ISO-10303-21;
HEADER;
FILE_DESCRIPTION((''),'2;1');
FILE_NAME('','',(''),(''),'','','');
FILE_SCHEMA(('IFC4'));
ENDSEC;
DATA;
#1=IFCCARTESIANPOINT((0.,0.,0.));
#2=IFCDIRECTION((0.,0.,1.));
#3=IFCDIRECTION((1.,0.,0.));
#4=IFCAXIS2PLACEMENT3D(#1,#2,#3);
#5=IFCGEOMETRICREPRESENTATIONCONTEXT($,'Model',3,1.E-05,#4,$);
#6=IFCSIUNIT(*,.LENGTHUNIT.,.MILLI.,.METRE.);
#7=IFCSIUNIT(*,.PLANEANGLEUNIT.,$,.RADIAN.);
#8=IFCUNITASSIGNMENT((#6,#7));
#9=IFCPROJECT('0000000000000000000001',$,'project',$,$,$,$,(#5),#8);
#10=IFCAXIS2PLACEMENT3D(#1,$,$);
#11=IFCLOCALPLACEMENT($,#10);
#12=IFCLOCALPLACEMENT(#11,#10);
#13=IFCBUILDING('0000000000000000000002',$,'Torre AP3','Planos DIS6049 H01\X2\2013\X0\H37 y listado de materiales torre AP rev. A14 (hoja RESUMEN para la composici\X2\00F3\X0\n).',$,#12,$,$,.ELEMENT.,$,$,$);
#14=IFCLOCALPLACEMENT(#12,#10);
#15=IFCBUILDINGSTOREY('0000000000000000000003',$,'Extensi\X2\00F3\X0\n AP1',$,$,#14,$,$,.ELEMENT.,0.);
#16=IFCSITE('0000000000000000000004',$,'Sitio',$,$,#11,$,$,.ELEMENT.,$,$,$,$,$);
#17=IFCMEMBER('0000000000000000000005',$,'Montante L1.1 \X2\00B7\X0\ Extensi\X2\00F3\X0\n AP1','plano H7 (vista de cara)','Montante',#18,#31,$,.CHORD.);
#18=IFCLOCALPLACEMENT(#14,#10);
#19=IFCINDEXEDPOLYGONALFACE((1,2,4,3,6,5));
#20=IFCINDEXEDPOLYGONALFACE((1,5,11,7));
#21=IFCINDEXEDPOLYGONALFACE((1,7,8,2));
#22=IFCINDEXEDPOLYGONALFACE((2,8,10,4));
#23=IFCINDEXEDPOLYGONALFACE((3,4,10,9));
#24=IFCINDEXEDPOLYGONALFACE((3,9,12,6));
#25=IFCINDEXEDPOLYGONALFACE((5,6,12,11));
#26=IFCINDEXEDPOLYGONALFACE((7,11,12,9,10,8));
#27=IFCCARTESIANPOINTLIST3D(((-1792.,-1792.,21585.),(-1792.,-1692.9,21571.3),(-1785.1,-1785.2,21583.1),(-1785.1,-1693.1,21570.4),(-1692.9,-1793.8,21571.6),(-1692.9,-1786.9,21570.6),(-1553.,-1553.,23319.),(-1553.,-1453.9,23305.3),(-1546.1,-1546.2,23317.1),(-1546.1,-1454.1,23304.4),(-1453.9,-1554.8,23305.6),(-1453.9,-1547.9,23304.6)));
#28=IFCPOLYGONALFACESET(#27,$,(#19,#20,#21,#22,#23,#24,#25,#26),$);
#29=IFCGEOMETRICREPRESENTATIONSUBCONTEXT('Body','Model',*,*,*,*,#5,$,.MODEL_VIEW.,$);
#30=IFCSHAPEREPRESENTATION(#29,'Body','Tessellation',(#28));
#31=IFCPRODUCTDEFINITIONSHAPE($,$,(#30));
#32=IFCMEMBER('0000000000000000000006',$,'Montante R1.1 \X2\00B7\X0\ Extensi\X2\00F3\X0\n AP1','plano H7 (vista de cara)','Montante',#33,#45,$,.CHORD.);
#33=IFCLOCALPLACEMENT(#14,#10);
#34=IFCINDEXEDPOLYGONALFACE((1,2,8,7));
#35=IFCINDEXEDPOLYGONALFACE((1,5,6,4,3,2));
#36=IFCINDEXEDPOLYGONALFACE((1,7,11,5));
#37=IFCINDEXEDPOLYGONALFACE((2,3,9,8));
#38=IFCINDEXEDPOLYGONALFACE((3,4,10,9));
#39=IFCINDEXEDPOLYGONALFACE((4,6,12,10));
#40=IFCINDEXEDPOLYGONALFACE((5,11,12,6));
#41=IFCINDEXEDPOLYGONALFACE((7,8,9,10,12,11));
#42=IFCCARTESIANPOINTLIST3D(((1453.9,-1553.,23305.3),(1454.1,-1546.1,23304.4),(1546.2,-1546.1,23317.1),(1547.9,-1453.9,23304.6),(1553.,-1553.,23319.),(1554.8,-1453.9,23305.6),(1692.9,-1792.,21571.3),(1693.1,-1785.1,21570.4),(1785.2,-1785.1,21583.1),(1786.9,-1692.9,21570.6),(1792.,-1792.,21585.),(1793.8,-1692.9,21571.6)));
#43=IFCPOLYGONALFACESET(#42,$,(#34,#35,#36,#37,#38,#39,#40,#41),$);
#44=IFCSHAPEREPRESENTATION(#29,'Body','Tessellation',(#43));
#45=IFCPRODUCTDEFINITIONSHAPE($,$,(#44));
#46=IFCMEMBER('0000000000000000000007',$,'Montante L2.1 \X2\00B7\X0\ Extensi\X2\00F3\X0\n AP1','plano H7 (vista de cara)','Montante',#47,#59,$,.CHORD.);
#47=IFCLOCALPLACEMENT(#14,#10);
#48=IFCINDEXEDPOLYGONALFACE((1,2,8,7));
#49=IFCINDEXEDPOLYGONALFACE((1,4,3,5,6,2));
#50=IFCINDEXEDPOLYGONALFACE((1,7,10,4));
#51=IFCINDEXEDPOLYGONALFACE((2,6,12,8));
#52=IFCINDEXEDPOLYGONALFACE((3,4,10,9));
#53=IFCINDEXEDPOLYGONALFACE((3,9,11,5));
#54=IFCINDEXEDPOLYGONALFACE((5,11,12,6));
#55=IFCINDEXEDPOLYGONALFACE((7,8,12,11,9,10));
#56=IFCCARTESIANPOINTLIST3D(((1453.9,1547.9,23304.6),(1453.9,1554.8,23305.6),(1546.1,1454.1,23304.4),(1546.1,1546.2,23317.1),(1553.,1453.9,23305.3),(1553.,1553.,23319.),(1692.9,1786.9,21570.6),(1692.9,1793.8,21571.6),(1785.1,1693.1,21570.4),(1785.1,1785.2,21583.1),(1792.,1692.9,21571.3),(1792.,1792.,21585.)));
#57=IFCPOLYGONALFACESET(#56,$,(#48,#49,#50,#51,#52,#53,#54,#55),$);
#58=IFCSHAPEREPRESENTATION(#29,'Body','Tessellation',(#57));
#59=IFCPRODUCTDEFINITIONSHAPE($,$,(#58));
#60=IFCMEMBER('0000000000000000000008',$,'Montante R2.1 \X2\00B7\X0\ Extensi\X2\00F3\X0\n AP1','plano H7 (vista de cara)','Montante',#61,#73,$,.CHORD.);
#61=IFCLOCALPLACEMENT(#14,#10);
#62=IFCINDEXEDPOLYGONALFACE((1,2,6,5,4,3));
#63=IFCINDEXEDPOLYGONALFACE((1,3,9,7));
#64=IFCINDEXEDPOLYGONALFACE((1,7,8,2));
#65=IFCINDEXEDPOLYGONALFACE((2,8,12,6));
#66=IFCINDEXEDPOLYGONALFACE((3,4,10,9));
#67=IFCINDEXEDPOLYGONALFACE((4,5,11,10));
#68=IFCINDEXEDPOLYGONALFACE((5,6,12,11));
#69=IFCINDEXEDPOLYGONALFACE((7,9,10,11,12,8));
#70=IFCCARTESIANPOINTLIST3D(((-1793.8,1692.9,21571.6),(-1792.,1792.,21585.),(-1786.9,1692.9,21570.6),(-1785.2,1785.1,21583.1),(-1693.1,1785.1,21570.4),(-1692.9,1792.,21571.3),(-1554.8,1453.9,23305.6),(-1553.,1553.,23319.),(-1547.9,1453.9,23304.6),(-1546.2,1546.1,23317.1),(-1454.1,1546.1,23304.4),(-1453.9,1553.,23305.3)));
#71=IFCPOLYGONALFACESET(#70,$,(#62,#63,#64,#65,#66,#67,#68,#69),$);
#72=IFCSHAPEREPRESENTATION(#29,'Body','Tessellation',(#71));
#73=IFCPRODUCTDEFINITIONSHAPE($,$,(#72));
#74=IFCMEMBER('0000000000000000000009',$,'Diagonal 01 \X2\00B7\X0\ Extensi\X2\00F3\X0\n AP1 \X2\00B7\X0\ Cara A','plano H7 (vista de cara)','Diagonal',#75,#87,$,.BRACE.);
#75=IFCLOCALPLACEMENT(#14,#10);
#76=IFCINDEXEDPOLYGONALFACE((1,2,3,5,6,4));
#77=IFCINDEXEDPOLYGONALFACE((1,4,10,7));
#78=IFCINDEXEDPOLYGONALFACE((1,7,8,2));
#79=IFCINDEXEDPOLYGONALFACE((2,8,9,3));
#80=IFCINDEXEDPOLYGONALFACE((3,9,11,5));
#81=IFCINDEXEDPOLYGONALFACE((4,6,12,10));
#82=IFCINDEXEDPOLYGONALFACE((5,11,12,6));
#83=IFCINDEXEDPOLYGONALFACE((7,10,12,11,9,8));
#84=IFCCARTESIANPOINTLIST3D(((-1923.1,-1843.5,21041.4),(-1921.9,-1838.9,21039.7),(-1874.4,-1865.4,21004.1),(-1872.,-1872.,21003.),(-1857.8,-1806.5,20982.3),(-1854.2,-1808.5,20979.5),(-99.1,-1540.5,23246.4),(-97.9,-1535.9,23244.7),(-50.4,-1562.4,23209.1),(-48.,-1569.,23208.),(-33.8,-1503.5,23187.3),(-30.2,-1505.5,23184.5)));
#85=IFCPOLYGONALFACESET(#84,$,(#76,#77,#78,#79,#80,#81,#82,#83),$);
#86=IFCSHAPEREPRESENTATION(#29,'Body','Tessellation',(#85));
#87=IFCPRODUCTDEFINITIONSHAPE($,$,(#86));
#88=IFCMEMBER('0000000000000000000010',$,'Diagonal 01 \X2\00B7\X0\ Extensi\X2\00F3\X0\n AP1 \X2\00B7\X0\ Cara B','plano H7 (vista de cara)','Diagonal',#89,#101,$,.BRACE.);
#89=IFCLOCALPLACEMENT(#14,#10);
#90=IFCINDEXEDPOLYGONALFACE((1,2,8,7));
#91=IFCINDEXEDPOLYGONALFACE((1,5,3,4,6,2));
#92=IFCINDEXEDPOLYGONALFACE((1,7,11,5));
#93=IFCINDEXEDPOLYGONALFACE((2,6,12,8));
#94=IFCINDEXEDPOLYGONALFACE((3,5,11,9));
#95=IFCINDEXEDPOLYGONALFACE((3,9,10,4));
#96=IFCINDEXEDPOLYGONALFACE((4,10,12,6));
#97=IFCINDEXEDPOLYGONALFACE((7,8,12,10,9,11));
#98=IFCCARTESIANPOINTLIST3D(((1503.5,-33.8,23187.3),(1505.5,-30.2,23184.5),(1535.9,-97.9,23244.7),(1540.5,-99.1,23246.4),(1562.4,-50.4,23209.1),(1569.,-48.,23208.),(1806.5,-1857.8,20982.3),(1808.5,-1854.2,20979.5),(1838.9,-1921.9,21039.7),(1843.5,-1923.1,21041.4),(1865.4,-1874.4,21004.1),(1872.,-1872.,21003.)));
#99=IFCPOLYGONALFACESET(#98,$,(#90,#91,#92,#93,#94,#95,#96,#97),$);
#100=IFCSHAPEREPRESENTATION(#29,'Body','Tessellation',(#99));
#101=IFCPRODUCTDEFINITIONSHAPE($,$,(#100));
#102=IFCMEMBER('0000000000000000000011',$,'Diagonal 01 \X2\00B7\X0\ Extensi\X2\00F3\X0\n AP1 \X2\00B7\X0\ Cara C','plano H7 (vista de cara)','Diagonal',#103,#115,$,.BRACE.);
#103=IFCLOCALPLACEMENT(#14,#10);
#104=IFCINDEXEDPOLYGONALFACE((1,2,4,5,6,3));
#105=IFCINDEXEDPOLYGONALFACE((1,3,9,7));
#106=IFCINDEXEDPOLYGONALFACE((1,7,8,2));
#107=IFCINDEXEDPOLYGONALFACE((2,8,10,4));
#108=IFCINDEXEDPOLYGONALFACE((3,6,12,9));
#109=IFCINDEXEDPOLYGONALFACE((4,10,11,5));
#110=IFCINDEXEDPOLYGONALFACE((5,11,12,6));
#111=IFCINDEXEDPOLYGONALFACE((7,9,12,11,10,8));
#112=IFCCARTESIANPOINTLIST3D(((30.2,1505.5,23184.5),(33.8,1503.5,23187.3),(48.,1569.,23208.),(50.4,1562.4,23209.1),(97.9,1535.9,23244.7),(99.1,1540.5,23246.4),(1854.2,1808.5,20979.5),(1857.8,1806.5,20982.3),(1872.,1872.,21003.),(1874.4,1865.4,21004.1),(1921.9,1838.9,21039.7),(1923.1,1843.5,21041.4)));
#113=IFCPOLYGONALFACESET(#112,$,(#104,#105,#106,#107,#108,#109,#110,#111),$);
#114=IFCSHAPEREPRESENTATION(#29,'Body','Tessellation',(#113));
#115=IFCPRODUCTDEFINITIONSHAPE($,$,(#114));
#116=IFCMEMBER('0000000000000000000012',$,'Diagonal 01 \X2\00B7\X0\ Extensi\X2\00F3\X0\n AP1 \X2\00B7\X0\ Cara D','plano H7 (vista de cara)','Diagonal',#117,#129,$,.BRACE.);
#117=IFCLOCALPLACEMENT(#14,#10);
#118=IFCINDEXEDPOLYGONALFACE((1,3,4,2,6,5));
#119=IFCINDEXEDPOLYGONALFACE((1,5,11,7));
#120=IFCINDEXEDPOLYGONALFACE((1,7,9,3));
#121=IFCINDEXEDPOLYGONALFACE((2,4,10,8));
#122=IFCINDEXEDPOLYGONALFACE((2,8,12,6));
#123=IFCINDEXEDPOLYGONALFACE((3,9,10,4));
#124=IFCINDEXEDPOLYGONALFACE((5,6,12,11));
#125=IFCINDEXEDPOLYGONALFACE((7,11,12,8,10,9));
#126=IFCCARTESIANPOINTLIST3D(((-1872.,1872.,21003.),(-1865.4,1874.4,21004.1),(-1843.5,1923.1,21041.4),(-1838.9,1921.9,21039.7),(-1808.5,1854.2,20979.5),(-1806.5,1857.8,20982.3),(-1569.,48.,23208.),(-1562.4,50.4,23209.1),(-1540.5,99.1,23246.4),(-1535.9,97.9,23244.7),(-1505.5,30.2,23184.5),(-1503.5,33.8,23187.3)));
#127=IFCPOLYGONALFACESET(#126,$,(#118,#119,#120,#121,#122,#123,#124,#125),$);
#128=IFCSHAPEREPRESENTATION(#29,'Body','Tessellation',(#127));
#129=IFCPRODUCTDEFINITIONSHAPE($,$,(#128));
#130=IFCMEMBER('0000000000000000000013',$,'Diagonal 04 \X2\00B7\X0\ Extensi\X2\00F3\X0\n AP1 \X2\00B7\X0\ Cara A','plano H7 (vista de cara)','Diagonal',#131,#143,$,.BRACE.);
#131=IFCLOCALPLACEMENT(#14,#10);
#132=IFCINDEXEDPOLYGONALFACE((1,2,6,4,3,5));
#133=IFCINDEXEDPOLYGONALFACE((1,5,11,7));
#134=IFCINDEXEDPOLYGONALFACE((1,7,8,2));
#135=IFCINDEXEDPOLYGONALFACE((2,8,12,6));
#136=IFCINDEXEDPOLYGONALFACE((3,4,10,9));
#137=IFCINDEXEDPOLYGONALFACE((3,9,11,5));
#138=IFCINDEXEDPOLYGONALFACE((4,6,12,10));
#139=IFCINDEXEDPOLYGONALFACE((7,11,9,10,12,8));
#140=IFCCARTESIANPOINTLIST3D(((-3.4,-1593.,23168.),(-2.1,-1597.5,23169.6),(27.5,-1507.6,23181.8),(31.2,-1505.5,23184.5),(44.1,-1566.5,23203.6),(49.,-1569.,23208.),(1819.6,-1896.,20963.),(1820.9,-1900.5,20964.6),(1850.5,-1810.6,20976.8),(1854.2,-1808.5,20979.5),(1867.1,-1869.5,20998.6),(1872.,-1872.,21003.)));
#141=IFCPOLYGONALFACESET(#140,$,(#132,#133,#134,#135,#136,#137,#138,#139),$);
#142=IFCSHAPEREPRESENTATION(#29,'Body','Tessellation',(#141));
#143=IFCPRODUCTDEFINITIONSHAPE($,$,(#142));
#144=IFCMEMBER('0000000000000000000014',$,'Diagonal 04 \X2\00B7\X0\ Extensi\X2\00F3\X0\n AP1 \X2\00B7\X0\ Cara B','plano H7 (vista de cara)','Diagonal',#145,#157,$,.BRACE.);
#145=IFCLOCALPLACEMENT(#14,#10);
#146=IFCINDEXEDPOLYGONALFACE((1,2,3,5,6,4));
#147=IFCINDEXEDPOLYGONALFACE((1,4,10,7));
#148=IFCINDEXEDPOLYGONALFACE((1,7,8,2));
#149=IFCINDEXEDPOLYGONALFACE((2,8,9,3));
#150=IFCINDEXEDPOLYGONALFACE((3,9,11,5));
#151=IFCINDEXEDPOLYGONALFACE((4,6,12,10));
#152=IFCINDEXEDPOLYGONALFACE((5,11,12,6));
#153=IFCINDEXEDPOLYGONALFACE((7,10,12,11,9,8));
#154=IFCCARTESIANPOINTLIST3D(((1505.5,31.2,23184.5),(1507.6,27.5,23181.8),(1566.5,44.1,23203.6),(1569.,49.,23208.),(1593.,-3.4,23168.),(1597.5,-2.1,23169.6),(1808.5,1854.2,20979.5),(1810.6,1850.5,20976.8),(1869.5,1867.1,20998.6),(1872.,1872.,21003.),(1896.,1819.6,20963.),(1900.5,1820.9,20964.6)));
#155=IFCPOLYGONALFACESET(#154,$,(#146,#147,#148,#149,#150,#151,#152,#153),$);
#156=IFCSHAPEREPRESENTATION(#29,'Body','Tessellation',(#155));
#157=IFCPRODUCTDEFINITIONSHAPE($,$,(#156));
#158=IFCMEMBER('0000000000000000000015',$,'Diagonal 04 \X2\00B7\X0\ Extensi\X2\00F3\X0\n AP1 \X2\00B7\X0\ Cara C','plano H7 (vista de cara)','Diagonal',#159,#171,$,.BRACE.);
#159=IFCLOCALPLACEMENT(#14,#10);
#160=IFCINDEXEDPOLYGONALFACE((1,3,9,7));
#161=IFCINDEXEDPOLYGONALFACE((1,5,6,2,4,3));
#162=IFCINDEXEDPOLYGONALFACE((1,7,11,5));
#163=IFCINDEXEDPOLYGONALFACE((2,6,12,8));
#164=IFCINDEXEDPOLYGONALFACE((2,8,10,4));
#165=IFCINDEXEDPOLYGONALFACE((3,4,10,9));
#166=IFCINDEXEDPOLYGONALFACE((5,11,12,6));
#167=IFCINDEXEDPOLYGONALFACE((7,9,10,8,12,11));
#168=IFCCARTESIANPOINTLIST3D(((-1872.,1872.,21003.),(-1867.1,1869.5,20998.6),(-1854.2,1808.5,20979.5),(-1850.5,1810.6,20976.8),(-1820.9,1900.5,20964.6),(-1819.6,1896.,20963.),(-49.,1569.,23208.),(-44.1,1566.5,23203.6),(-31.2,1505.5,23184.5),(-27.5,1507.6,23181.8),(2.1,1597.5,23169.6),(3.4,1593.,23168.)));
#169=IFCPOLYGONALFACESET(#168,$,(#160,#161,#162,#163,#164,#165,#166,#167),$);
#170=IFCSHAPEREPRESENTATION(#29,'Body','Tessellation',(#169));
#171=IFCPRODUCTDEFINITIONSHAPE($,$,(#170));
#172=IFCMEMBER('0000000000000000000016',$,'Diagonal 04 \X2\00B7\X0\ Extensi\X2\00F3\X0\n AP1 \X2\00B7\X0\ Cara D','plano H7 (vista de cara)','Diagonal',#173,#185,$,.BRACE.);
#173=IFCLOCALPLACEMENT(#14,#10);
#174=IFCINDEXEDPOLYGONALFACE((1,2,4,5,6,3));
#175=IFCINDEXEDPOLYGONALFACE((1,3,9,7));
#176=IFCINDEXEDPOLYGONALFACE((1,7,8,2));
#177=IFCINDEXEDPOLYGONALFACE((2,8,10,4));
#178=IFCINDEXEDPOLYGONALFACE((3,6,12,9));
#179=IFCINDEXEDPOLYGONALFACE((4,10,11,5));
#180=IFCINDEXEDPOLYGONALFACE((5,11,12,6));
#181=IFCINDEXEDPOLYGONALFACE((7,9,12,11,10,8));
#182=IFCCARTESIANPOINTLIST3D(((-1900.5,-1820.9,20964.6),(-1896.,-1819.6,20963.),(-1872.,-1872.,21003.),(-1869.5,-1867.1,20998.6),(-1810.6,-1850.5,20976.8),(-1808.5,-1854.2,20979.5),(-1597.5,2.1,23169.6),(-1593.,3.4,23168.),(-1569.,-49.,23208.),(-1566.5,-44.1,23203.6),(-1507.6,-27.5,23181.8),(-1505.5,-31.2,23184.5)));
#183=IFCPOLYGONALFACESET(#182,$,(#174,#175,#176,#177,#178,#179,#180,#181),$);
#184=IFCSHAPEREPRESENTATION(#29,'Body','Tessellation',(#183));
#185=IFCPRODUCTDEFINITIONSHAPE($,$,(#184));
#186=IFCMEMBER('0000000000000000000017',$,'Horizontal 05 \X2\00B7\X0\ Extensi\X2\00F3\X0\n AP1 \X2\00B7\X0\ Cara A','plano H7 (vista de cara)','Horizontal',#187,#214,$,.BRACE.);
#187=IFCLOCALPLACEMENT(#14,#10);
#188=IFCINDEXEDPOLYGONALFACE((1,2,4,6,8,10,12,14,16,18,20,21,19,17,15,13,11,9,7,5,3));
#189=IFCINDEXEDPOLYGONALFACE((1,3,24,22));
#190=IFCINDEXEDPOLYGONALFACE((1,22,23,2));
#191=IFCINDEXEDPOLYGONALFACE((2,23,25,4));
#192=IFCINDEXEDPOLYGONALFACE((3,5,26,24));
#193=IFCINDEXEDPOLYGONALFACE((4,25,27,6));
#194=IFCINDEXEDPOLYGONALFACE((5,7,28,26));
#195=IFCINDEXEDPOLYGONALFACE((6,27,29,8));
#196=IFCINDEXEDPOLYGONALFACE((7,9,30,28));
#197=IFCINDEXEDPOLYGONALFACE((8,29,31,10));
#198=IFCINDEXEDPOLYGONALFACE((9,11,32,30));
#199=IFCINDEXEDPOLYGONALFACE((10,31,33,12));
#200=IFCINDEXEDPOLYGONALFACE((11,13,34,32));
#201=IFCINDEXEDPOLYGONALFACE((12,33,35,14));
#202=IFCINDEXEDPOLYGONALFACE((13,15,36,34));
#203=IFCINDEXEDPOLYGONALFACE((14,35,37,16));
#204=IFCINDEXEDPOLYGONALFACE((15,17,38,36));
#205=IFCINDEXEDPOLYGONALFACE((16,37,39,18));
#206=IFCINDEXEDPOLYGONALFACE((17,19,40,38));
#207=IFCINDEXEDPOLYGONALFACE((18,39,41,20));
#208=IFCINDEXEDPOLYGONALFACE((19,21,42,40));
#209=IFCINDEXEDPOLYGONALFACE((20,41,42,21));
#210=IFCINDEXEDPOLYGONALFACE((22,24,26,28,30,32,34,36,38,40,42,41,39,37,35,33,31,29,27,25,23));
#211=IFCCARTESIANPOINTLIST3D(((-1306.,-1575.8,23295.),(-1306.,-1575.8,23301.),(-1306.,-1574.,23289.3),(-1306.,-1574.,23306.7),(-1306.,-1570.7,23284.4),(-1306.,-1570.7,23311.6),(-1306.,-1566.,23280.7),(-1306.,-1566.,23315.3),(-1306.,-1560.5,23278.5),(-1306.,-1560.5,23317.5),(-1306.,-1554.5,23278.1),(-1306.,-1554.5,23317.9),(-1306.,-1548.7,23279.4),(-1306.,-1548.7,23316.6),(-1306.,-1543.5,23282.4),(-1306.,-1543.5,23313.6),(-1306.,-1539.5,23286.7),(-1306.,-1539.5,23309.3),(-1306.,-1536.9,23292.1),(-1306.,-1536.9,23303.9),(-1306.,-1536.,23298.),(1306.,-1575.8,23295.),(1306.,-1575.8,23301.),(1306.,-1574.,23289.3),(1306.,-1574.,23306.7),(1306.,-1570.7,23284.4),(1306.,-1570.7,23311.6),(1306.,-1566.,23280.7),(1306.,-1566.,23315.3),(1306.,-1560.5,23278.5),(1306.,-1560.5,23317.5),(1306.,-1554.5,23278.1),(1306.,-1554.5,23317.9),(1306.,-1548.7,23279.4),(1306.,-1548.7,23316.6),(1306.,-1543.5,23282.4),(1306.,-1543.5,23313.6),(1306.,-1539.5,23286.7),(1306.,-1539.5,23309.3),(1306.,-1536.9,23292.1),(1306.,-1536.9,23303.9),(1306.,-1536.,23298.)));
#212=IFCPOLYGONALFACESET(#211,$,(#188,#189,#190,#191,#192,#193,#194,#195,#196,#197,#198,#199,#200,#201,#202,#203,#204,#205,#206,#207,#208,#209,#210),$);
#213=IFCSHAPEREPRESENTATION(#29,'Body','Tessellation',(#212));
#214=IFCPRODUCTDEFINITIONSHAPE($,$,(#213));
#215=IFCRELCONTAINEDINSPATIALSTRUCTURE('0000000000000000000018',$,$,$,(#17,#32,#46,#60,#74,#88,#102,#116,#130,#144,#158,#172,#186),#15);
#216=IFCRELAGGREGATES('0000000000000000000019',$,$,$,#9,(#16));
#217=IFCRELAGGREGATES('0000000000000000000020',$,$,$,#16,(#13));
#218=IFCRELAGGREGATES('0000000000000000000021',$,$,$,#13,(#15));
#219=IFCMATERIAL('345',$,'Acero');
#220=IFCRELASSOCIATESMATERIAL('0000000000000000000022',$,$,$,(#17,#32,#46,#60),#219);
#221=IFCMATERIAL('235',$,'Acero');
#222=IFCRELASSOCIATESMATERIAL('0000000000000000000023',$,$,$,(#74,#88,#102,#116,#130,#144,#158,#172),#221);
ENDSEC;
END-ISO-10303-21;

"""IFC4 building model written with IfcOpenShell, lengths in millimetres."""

from ifc_helpers import new_model, si_unit, frame, frame_2d, origin, origin_with_axes, place, context, subcontext, project, spatial, circle, l_section, extrude, material, element, save


model = new_model("IFC4")

# Units and contexts
model_context = context("Model", 3, precision=1e-05, world=origin_with_axes())
body_context = subcontext(model_context, "Body", "Model", "MODEL_VIEW")
ifc_project = project(units=[si_unit("LENGTHUNIT", "METRE", prefix="MILLI"), si_unit("PLANEANGLEUNIT", "RADIAN")], contexts=[model_context])

# Site, building, storey
site_placement = place(None, origin())
site = spatial("IfcSite", under=ifc_project, at=site_placement, Name="Sitio", CompositionType="ELEMENT")
building_placement = place(site_placement, origin())
building = spatial("IfcBuilding", under=site, at=building_placement, Name="Torre AP3", Description="Planos DIS6049 H01–H37 y listado de materiales torre AP rev. A14 (hoja RESUMEN para la composición).", CompositionType="ELEMENT")
storey_placement = place(building_placement, origin())
storey = spatial("IfcBuildingStorey", under=building, at=storey_placement, Name="Extensión AP1", CompositionType="ELEMENT", Elevation=0.0)

# Members
ifc_material_1 = material(Name="345", Category="Acero")
for number, where, z_axis, x_axis, name in (
    (1, (-1792.0, -1792.0, 21585.0), (0.135285, 0.135285, 0.981527), (0.990807, -0.018472, -0.134018), "Montante L1.1 · Extensión AP1"),
    (2, (1792.0, -1792.0, 21585.0), (-0.135285, 0.135285, 0.981527), (0.018472, 0.990807, -0.134018), "Montante R1.1 · Extensión AP1"),
    (3, (1792.0, 1792.0, 21585.0), (-0.135285, -0.135285, 0.981527), (-0.990807, 0.018472, -0.134018), "Montante L2.1 · Extensión AP1"),
    (4, (-1792.0, 1792.0, 21585.0), (0.135285, -0.135285, 0.981527), (-0.018472, -0.990807, -0.134018), "Montante R2.1 · Extensión AP1"),
):
    element("IfcMember", number, at=place(storey_placement, frame(where, z_axis=z_axis, x_axis=x_axis)), inside=storey, material=ifc_material_1, Name=name, Description="plano H7 (vista de cara)", ObjectType="Montante", PredefinedType="CHORD", context=body_context, shape_type="SweptSolid", body=[
        extrude(l_section(Depth=100.0, Width=100.0, Thickness=7.0, at=frame_2d((50.0, 50.0))), None, (0.0, 0.0, 1.0), 1766.6),
    ])
ifc_material_2 = material(Name="235", Category="Acero")
for number, where, z_axis, x_axis, name in (
    (5, (-1872.0, -1872.0, 21003.0), (0.633853, 0.105295, 0.766253), (0.25455, 0.907102, -0.335216), "Diagonal 01 · Extensión AP1 · Cara A"),
    (6, (1872.0, -1872.0, 21003.0), (-0.105295, 0.633853, 0.766253), (-0.907102, 0.25455, -0.335216), "Diagonal 01 · Extensión AP1 · Cara B"),
    (7, (1872.0, 1872.0, 21003.0), (-0.633853, -0.105295, 0.766253), (-0.25455, -0.907102, -0.335216), "Diagonal 01 · Extensión AP1 · Cara C"),
    (8, (-1872.0, 1872.0, 21003.0), (0.105295, -0.633853, 0.766253), (0.907102, -0.25455, -0.335216), "Diagonal 01 · Extensión AP1 · Cara D"),
):
    element("IfcMember", number, at=place(storey_placement, frame(where, z_axis=z_axis, x_axis=x_axis)), inside=storey, material=ifc_material_2, Name=name, Description="plano H7 (vista de cara)", ObjectType="Diagonal", PredefinedType="BRACE", context=body_context, shape_type="SweptSolid", body=[
        extrude(l_section(Depth=70.0, Width=70.0, Thickness=5.0, at=frame_2d((35.0, 35.0))), None, (0.0, 0.0, 1.0), 2877.6),
    ])
for number, where, z_axis, x_axis, name in (
    (9, (1872.0, -1872.0, 21003.0), (-0.633645, 0.105318, 0.766422), (-0.254835, 0.906984, -0.33532), "Diagonal 04 · Extensión AP1 · Cara A"),
    (10, (1872.0, 1872.0, 21003.0), (-0.105318, -0.633645, 0.766422), (-0.906984, -0.254835, -0.33532), "Diagonal 04 · Extensión AP1 · Cara B"),
    (11, (-1872.0, 1872.0, 21003.0), (0.633645, -0.105318, 0.766422), (0.254835, -0.906984, -0.33532), "Diagonal 04 · Extensión AP1 · Cara C"),
    (12, (-1872.0, -1872.0, 21003.0), (0.105318, 0.633645, 0.766422), (0.906984, 0.254835, -0.33532), "Diagonal 04 · Extensión AP1 · Cara D"),
):
    element("IfcMember", number, at=place(storey_placement, frame(where, z_axis=z_axis, x_axis=x_axis)), inside=storey, material=ifc_material_2, Name=name, Description="plano H7 (vista de cara)", ObjectType="Diagonal", PredefinedType="BRACE", context=body_context, shape_type="SweptSolid", body=[
        extrude(l_section(Depth=70.0, Width=70.0, Thickness=5.0, at=frame_2d((35.0, 35.0))), None, (0.0, 0.0, 1.0), 2877.0),
    ])
for number, where, z_axis, x_axis, name in (
    (13, (1306.0, -1556.0, 23298.0), (-1.0, 0.0, 0.0), (0.0, 1.0, 0.0), "Horizontal 05 · Extensión AP1 · Cara A"),
):
    element("IfcMember", number, at=place(storey_placement, frame(where, z_axis=z_axis, x_axis=x_axis)), inside=storey, Name=name, Description="plano H7 (vista de cara)", ObjectType="Horizontal", PredefinedType="BRACE", context=body_context, shape_type="SweptSolid", body=[
        extrude(circle(Radius=20.0), None, (0.0, 0.0, 1.0), 2612.0),
    ])

save(model, "model.ifc")
